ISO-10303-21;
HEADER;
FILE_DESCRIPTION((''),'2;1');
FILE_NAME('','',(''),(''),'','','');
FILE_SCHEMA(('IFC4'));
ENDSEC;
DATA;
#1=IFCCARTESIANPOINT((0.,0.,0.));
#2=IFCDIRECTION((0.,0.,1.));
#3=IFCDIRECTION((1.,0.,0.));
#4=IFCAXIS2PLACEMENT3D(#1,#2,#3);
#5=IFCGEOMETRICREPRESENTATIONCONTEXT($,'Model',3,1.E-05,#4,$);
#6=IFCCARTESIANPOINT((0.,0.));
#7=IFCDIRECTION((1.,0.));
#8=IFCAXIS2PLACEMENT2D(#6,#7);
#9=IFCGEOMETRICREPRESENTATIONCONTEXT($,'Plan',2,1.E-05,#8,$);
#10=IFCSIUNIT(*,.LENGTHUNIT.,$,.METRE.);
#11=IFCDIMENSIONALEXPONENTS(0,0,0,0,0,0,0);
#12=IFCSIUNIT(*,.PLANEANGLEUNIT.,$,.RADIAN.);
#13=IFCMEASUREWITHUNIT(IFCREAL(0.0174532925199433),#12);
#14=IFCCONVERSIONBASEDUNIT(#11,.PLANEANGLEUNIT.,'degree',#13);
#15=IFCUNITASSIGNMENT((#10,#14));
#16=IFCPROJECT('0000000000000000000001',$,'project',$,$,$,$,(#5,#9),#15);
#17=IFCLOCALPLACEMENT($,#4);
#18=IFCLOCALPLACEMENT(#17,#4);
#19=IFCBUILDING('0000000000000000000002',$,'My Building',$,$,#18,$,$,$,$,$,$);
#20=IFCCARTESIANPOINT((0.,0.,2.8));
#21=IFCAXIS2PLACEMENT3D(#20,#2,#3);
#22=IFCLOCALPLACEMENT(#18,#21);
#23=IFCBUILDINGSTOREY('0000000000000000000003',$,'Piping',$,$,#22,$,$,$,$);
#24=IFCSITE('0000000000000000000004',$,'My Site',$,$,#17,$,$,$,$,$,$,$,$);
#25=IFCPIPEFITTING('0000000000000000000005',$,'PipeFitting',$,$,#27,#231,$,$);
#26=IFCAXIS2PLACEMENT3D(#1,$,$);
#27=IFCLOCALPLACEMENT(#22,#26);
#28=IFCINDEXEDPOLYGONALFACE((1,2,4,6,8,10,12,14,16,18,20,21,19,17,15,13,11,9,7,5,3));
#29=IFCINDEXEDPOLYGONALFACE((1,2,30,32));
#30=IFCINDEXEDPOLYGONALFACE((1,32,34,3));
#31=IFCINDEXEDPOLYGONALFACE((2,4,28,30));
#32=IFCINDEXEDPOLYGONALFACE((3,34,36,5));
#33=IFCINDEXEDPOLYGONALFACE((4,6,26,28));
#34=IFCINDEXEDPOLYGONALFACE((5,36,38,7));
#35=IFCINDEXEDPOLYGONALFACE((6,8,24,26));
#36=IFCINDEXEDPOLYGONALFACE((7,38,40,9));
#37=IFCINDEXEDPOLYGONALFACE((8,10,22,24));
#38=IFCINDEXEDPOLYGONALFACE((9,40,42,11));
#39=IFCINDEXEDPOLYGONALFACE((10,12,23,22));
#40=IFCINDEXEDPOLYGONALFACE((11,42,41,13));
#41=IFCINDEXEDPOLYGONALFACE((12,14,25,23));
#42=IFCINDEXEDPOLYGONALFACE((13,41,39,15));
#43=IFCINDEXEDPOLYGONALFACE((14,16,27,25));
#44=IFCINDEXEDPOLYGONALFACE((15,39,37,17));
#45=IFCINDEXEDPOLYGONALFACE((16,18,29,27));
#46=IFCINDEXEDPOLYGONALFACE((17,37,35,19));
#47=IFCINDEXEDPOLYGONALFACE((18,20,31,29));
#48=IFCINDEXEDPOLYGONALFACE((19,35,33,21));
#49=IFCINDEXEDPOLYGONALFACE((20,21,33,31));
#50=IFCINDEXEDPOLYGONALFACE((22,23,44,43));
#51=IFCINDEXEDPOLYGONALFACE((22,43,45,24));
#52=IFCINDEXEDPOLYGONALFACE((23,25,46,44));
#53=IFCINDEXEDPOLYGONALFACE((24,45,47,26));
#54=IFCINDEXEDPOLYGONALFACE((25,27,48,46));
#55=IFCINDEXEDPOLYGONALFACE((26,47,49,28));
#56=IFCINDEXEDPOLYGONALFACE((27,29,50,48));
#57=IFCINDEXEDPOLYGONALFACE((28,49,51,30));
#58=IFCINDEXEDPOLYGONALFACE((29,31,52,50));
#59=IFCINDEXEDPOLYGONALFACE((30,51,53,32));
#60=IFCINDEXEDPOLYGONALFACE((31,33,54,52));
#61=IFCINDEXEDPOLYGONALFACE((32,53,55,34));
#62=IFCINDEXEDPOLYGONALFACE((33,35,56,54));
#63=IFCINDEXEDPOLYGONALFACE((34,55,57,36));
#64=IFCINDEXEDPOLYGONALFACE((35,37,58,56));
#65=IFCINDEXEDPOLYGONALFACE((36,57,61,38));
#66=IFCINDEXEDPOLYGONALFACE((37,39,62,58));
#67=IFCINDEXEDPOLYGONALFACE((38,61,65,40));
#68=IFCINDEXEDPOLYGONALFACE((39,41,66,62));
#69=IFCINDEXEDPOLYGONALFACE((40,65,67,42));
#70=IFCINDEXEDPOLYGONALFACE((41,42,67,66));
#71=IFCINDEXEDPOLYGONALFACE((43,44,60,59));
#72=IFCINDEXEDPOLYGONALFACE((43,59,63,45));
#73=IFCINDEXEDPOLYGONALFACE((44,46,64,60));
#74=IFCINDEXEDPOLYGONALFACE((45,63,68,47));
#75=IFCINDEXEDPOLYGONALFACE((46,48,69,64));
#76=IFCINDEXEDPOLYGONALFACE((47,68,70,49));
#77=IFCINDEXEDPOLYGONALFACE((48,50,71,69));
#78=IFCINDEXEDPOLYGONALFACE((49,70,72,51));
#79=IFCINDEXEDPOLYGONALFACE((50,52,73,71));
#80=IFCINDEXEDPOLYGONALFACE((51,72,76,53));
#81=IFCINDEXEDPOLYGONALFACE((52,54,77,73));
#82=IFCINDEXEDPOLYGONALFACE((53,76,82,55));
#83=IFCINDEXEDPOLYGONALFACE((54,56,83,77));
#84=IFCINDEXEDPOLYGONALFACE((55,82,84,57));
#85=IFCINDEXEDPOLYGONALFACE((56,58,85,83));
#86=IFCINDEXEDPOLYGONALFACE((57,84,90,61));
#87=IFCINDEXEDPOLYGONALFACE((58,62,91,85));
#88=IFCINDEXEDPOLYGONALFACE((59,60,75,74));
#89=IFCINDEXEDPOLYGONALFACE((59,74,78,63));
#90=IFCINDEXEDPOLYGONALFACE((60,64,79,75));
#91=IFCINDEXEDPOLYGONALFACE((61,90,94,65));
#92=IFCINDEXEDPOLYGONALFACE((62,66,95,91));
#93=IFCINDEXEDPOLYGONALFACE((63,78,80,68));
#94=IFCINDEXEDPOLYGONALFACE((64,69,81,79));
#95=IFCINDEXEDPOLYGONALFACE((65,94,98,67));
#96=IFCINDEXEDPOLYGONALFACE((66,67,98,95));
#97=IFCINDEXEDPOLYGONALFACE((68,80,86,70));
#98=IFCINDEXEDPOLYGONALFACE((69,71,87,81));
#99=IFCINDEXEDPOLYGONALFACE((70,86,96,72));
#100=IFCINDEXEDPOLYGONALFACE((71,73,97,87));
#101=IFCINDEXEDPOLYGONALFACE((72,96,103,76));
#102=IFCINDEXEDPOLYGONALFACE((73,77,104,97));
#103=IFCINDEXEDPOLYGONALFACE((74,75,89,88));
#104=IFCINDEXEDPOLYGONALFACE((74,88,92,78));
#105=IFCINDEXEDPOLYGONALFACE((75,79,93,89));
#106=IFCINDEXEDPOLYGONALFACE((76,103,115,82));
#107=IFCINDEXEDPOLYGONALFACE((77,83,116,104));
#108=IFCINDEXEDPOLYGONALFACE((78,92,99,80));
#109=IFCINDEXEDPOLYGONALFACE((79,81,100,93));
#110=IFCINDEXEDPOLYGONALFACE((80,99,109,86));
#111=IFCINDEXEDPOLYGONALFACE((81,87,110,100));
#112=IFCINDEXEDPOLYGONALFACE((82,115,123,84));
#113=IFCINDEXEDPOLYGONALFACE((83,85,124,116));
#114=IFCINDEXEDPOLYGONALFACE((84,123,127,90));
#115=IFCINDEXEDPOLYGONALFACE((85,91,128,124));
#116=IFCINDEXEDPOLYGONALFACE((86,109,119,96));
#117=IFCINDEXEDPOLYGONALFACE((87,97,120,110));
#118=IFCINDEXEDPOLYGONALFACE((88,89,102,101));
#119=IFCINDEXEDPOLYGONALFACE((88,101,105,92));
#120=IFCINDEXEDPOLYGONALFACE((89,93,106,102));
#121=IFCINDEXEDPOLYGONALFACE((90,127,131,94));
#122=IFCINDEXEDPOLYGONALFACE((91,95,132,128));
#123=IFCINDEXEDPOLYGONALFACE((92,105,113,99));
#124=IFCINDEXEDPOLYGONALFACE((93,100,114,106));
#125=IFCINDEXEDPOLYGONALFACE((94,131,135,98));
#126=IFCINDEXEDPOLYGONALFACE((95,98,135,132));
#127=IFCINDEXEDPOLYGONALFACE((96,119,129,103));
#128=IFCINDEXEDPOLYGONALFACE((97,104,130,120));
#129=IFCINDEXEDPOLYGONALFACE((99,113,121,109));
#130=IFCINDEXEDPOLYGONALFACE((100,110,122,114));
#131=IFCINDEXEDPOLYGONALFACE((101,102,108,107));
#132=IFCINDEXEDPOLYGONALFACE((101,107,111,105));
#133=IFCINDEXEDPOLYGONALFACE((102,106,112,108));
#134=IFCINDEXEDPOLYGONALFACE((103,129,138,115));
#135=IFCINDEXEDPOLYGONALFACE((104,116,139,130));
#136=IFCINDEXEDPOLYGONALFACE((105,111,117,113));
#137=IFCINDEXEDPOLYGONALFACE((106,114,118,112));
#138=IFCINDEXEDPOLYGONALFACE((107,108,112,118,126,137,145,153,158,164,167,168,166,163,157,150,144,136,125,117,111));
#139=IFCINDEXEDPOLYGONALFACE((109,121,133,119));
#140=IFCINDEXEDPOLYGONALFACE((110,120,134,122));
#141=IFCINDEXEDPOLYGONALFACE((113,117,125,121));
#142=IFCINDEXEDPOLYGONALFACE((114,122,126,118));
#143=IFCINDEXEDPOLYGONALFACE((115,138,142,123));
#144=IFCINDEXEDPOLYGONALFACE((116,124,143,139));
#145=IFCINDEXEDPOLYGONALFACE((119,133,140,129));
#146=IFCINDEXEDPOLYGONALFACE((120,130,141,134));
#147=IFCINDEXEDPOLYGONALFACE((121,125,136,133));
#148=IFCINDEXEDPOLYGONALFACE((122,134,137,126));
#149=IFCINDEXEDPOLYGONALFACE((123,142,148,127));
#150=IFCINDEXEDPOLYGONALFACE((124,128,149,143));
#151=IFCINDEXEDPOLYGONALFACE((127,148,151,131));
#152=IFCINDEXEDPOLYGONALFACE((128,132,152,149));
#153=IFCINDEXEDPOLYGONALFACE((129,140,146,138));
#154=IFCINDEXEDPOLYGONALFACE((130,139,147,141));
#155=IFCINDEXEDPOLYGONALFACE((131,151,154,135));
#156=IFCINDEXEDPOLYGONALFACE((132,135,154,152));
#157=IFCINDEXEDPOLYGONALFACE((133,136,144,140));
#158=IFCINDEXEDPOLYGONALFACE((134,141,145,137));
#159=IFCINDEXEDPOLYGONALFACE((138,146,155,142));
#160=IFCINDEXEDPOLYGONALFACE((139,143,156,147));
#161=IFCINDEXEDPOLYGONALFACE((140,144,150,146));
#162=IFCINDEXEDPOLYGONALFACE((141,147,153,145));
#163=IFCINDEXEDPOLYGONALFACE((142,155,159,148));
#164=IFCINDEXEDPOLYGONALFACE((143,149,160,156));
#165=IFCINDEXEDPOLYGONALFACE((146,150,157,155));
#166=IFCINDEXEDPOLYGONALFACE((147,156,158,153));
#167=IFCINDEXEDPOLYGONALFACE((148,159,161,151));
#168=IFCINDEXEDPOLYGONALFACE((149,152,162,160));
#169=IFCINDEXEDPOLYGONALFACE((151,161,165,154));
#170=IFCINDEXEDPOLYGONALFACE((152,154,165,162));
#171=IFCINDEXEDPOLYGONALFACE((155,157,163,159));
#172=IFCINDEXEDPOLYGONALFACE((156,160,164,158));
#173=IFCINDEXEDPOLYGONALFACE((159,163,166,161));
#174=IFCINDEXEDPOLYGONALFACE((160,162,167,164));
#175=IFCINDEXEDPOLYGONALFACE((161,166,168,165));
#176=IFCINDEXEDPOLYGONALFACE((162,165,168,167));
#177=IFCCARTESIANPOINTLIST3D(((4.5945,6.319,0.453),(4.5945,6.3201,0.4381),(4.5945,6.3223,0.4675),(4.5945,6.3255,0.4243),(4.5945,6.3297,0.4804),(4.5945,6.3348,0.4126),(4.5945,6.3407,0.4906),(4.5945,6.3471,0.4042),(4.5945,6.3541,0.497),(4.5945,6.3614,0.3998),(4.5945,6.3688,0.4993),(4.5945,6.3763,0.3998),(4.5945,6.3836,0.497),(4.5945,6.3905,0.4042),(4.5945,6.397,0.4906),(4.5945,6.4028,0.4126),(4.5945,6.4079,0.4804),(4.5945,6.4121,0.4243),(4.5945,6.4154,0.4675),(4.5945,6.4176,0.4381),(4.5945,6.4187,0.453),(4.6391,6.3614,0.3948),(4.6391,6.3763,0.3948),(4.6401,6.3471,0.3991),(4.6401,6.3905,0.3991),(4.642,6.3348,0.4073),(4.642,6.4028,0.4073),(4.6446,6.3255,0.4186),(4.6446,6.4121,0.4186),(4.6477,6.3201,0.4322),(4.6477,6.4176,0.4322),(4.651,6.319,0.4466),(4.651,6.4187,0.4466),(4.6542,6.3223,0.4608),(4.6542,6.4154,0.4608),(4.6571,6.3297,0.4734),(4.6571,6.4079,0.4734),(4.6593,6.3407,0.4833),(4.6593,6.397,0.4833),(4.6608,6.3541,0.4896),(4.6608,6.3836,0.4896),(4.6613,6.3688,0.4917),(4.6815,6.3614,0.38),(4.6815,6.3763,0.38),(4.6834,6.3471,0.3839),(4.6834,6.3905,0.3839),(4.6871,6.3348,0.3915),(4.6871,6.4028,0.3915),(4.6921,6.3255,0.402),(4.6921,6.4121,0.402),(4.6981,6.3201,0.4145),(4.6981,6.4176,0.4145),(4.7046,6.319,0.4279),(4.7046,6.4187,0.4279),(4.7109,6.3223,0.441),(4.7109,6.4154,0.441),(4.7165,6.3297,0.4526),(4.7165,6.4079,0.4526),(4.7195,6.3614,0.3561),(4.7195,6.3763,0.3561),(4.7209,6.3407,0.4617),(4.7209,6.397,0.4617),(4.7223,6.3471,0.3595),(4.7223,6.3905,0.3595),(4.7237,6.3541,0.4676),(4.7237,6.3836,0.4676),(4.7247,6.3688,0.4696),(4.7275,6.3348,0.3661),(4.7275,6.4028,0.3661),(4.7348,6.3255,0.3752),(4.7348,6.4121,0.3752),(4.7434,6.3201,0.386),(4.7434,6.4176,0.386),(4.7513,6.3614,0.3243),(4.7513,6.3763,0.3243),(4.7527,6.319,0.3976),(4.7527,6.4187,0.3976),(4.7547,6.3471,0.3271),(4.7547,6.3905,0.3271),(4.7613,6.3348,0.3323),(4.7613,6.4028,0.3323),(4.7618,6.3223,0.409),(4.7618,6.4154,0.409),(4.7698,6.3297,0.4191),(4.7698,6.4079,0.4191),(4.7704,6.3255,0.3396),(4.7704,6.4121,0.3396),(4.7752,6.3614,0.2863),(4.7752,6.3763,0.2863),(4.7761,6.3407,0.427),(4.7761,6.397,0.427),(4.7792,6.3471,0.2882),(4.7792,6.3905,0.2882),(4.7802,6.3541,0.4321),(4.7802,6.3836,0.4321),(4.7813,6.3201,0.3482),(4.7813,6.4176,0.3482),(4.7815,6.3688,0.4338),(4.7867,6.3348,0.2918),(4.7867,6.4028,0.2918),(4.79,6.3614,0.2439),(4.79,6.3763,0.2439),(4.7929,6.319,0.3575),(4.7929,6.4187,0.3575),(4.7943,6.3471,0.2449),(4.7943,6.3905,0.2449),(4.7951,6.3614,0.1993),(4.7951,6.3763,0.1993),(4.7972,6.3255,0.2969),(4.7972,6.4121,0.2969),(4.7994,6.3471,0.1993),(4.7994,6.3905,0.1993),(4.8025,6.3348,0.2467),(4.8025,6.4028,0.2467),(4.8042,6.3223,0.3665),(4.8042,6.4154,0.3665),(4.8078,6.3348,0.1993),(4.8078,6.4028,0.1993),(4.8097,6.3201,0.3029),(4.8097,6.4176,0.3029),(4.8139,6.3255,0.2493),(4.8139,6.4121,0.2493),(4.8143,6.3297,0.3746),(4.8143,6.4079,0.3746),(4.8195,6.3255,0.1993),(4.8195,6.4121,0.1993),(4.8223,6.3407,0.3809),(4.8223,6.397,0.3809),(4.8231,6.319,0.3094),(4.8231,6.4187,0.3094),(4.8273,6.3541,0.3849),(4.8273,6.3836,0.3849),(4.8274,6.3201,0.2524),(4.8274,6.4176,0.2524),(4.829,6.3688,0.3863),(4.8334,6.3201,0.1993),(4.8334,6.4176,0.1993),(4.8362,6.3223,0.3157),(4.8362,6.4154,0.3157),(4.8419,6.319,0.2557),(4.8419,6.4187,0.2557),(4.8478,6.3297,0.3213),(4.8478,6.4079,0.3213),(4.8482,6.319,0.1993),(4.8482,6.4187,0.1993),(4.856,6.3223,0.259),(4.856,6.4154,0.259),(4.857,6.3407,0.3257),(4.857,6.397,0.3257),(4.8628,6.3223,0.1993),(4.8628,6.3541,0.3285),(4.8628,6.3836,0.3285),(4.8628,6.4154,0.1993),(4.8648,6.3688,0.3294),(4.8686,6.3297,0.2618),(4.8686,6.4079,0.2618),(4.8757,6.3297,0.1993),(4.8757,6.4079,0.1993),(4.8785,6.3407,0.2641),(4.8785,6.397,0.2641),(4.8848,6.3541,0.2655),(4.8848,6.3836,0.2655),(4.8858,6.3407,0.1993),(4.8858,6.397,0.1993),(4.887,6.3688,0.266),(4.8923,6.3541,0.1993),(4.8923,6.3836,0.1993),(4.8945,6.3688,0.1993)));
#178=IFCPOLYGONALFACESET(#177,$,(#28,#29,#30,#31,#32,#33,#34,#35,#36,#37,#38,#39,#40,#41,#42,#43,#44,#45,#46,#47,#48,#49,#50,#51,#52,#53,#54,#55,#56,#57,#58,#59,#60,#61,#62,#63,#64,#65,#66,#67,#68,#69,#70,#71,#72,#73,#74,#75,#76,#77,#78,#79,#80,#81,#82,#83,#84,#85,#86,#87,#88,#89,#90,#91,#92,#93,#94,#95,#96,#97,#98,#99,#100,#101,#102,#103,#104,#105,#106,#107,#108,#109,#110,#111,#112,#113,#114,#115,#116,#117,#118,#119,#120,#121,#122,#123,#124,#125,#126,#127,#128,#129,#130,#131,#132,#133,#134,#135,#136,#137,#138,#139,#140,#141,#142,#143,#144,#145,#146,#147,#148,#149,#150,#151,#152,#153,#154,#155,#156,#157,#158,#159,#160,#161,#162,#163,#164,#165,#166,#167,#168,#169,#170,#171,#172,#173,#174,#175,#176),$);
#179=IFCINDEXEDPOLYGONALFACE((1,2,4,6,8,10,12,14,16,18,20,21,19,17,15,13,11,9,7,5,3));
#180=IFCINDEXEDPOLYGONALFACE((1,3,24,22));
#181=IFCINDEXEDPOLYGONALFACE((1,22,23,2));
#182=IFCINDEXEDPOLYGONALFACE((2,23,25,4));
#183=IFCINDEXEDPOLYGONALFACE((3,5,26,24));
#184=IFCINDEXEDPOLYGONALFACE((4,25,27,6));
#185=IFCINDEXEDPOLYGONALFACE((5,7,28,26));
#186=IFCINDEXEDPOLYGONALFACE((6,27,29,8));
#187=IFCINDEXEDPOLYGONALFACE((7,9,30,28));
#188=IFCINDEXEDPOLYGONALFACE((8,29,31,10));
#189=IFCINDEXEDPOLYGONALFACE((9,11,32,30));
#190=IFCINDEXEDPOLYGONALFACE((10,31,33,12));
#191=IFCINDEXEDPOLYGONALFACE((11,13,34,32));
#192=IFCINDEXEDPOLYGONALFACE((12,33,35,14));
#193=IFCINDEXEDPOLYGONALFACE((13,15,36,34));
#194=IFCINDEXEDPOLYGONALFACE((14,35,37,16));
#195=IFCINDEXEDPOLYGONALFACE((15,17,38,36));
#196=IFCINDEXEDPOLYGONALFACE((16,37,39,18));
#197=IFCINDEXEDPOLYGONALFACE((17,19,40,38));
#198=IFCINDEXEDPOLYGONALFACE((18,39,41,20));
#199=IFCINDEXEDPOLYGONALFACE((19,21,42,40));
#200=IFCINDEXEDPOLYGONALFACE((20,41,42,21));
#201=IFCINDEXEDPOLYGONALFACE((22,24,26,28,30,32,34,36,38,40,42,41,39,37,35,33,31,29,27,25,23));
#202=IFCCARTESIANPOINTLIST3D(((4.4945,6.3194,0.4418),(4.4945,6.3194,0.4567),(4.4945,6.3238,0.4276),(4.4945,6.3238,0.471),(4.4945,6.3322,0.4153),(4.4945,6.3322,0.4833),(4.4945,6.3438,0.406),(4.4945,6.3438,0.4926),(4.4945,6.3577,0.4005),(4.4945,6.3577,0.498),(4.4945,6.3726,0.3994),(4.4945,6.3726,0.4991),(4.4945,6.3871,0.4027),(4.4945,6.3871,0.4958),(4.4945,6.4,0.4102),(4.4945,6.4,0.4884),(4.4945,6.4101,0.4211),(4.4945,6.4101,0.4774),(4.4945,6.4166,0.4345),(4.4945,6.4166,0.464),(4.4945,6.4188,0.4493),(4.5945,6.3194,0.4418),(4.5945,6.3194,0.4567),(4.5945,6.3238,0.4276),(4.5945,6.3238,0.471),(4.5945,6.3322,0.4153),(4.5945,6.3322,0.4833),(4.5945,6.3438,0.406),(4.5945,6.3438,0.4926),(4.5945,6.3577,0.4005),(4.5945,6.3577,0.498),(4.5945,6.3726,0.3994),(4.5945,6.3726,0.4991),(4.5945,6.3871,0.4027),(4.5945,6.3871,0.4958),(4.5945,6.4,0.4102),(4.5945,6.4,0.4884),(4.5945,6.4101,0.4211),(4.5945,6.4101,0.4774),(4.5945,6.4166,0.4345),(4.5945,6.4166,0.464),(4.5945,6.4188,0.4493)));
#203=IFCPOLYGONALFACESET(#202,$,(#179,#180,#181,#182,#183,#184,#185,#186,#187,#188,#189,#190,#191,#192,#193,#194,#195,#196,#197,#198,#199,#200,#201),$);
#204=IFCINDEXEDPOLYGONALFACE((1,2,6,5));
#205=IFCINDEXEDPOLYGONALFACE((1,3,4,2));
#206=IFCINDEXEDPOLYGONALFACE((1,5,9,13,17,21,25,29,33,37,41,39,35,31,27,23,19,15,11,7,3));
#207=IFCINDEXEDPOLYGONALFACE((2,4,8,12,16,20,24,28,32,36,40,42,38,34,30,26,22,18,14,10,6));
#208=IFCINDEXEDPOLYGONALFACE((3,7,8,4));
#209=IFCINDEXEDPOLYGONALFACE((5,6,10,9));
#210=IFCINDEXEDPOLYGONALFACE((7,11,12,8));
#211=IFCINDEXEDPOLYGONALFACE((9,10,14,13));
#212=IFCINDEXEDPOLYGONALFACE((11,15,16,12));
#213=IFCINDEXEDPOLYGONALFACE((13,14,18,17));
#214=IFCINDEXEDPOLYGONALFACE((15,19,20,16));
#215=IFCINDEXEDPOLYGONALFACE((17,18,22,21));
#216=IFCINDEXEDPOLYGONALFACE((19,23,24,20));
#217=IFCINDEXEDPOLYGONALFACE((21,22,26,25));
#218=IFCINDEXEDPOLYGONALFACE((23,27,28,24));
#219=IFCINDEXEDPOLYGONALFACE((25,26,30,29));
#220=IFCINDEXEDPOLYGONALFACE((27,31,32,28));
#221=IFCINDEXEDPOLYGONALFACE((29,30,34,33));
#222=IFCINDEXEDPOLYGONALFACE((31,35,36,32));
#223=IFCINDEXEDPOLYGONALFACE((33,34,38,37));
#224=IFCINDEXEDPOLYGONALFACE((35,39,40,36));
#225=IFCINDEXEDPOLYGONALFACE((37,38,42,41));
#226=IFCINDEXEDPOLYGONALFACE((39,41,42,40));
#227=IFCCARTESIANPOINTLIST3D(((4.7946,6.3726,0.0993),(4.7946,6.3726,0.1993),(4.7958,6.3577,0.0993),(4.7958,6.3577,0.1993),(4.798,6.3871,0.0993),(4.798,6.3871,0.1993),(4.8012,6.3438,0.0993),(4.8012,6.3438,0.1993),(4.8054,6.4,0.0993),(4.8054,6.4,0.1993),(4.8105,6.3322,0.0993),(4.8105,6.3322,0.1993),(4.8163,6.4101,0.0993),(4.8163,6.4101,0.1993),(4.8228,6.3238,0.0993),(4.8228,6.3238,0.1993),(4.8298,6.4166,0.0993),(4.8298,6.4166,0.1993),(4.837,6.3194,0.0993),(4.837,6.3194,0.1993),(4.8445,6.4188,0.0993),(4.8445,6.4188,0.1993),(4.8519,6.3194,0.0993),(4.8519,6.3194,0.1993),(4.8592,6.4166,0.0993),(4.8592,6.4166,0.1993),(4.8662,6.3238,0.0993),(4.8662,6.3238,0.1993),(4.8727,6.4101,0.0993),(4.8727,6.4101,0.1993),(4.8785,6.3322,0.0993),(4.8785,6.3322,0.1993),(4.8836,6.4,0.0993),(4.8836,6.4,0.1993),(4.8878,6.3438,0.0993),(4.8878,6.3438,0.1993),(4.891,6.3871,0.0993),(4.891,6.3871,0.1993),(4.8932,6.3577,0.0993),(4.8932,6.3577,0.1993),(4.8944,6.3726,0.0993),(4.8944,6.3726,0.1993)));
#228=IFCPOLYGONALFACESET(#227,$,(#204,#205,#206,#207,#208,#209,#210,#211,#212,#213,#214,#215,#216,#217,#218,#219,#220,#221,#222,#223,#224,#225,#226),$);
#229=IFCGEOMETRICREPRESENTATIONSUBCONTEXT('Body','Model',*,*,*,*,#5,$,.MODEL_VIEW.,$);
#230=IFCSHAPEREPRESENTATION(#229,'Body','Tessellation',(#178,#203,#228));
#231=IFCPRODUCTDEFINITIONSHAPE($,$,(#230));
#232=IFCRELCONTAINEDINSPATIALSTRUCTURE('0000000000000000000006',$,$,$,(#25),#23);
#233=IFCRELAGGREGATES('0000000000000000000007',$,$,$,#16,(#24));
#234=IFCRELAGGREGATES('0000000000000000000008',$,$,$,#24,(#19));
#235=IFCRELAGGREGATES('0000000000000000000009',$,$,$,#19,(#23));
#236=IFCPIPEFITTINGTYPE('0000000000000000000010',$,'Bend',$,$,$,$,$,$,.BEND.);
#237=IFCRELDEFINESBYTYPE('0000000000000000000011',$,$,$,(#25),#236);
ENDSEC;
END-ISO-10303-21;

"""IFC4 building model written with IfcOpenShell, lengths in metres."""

from ifc_helpers import new_model, entity, si_unit, converted_unit, frame, origin_with_axes, origin_2d_with_axis, place, context, subcontext, project, spatial, circle, extrude, source, transform, mapped, type_object, type_shapes, element, save


model = new_model("IFC4")

# Units and contexts
model_context = context("Model", 3, precision=1e-05, world=origin_with_axes())
plan_context = context("Plan", 2, precision=1e-05, world=origin_2d_with_axis())
body_context = subcontext(model_context, "Body", "Model", "MODEL_VIEW")
ifc_project = project(units=[si_unit("LENGTHUNIT", "METRE"), converted_unit("PLANEANGLEUNIT", "degree", entity("IfcReal", 0.0174532925199433), si_unit("PLANEANGLEUNIT", "RADIAN"), dimensions=[0, 0, 0, 0, 0, 0, 0])], contexts=[model_context, plan_context])

# Site, building, storey
site_placement = place(None, origin_with_axes())
site = spatial("IfcSite", under=ifc_project, at=site_placement, Name="My Site")
building_placement = place(site_placement, origin_with_axes())
building = spatial("IfcBuilding", under=site, at=building_placement, Name="My Building")
storey_placement = place(building_placement, frame((0.0, 0.0, 2.8), z_axis=(0.0, 0.0, 1.0), x_axis=(1.0, 0.0, 0.0)))
storey = spatial("IfcBuildingStorey", under=building, at=storey_placement, Name="Piping")

# Pipe fitting
pipe_fitting_type_1 = type_object("IfcPipeFittingType", Name="Bend", PredefinedType="BEND")
shared_shape_1 = source(origin_with_axes(), body_context, "Body", "SolidModel", [
    entity("IfcSweptDiskSolid", entity("IfcIndexedPolyCurve", entity("IfcCartesianPointList3D", [[0.0, 0.0, 0.1], [0.0, -0.0732, 0.2768], [0.0, -0.25, 0.35]]), [entity("IfcArcIndex", [1, 2, 3])]), 0.05),
    extrude(circle(Radius=0.05), origin_with_axes(), (0.0, 0.0, 1.0), 0.1),
    extrude(circle(Radius=0.05), frame((0.0, -0.25, 0.35), z_axis=(0.0, -1.0, 0.0), x_axis=(1.0, 0.0, 0.0)), (0.0, 0.0, 1.0), 0.1),
])
type_shapes(pipe_fitting_type_1, [shared_shape_1])
for number, where, z_axis, x_axis, name in (
    (1, (4.4945, 6.3688, 0.4493), (1.0, 0.0, 0.0), (0.0, 1.0, 0.0), "PipeFitting"),
):
    element("IfcPipeFitting", number, at=place(storey_placement, frame(where, z_axis=z_axis, x_axis=x_axis)), inside=storey, type_object=pipe_fitting_type_1, Name=name, context=body_context, shape_type="MappedRepresentation", body=[
        mapped(shared_shape_1, transform((0.0, 0.0, 0.0), x_axis=(1.0, 0.0, 0.0), y_axis=(0.0, 1.0, 0.0), z_axis=(0.0, 0.0, 1.0), scale=1.0)),
    ])

save(model, "model.ifc")
